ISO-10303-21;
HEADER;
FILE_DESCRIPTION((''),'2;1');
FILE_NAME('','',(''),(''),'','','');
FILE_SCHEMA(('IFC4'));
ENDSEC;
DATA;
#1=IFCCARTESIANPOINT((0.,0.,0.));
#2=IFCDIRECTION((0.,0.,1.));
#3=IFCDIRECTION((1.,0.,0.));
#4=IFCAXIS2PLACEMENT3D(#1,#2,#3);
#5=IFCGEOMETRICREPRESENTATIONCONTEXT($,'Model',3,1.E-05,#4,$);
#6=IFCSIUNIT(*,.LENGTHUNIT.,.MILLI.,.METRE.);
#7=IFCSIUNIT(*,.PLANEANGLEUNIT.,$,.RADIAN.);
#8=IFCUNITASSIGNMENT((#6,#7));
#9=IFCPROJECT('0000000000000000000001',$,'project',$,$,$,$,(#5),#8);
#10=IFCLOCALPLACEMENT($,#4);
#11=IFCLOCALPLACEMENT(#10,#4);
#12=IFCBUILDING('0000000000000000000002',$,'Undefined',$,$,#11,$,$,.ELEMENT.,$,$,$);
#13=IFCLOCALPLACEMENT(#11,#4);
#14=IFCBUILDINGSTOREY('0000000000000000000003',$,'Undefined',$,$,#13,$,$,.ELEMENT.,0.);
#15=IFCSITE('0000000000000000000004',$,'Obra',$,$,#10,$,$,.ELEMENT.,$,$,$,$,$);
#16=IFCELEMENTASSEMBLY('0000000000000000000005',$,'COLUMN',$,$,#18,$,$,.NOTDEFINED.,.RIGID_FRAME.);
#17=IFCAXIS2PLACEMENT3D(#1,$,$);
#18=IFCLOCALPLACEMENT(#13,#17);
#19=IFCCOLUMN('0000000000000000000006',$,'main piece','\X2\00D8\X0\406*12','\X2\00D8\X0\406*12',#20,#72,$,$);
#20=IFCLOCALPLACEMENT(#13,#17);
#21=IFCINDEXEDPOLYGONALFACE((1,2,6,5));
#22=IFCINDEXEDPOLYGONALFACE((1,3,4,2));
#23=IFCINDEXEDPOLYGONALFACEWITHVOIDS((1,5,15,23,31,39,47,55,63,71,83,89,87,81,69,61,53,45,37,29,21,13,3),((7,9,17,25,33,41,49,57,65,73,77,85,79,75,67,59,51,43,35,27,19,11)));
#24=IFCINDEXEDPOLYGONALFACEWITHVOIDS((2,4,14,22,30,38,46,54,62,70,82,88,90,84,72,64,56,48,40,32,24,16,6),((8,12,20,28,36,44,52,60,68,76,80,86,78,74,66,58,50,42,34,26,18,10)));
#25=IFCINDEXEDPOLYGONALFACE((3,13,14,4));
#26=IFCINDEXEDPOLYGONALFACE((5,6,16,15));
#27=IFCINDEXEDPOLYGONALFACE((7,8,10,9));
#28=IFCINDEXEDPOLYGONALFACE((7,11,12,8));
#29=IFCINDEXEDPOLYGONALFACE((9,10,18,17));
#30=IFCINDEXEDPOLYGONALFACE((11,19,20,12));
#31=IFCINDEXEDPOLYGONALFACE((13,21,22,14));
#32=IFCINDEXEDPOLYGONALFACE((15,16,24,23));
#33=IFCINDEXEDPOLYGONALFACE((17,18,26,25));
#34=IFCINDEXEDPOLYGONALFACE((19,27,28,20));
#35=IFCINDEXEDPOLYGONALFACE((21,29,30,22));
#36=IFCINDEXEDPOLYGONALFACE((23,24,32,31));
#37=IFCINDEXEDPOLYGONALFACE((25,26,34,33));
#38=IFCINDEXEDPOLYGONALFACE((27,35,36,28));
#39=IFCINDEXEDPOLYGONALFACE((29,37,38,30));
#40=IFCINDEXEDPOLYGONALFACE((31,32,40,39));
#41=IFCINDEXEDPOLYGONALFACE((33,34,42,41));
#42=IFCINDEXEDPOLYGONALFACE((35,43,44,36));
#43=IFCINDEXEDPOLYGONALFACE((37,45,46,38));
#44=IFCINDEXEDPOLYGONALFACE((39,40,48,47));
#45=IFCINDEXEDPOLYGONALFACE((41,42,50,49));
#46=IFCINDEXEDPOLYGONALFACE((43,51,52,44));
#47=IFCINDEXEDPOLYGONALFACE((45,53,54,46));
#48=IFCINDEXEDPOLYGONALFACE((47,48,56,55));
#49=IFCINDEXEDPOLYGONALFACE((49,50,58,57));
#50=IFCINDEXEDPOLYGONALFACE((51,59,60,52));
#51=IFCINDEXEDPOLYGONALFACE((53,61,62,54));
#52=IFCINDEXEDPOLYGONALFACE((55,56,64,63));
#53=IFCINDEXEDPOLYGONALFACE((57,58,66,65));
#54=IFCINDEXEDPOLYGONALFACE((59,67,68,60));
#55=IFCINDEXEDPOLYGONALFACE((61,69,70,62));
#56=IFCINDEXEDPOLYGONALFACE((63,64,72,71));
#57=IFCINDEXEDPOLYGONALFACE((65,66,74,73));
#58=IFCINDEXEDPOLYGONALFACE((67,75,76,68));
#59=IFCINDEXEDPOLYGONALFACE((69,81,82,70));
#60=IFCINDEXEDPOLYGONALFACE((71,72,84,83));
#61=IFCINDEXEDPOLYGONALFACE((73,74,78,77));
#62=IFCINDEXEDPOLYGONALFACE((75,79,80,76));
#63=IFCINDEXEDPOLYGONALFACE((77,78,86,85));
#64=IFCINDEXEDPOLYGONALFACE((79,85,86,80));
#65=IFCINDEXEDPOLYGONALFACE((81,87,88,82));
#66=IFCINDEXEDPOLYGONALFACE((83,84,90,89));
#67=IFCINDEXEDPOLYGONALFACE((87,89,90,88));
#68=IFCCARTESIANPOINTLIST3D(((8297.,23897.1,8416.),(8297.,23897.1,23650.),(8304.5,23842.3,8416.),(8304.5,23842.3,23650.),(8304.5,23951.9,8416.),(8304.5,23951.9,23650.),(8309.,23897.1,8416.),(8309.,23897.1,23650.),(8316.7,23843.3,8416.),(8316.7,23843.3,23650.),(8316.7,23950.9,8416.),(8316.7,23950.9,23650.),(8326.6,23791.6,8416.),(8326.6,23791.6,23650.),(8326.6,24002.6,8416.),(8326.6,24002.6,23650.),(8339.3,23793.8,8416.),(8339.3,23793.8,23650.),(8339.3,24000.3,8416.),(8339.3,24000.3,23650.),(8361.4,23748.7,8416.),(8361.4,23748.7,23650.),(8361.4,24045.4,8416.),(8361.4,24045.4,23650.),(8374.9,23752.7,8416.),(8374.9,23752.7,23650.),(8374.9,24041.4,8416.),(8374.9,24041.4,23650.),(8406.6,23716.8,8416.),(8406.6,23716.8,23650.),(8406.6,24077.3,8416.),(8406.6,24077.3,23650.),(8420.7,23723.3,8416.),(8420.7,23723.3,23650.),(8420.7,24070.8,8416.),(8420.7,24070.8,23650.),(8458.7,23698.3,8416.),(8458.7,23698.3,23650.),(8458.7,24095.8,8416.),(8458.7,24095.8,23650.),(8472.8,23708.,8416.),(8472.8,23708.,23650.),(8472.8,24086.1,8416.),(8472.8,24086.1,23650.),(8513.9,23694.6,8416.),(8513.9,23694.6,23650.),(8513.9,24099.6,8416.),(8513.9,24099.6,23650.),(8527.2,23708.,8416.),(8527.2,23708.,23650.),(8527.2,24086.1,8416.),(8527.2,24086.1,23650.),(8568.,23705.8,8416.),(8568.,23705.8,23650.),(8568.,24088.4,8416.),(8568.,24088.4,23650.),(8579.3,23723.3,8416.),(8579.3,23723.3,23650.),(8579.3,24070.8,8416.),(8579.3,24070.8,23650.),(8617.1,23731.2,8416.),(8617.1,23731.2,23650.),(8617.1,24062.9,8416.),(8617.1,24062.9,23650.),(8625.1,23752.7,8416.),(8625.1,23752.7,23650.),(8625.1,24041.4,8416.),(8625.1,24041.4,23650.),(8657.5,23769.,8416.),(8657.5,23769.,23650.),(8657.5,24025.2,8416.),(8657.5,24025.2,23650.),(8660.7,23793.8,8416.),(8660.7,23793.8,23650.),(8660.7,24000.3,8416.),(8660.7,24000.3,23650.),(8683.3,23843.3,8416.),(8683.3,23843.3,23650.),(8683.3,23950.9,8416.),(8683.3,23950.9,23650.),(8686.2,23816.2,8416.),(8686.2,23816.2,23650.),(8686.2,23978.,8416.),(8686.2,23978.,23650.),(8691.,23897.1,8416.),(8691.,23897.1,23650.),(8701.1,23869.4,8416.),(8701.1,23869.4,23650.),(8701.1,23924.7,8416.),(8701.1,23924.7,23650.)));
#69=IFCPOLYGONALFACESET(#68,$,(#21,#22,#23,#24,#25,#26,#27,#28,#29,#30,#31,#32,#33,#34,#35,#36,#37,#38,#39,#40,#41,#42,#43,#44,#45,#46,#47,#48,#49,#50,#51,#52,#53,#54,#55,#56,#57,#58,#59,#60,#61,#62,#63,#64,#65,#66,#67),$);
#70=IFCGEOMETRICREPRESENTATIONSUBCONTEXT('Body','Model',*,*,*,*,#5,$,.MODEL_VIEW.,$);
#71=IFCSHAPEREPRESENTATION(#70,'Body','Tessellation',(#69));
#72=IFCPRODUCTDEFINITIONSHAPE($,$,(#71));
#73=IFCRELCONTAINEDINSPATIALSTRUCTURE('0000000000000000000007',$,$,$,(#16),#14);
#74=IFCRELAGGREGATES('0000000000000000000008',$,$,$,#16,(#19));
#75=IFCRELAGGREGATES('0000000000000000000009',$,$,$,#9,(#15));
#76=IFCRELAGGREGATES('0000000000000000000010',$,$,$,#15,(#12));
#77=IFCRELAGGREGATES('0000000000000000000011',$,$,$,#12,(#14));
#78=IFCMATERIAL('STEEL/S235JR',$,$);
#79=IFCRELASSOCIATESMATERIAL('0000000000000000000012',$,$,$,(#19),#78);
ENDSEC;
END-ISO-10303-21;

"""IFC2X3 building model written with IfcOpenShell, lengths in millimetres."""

from ifc_helpers import new_model, si_unit, frame, origin_with_axes, origin_2d_with_axis, place, context, subcontext, project, spatial, hollow_circle, extrude, clip, halfspace, material, element, aggregate, save


model = new_model("IFC2X3")

# Units and contexts
model_context = context("Model", 3, precision=1e-05, world=origin_with_axes())
body_context = subcontext(model_context, "Body", "Model", "MODEL_VIEW")
ifc_project = project(units=[si_unit("LENGTHUNIT", "METRE", prefix="MILLI"), si_unit("PLANEANGLEUNIT", "RADIAN")], contexts=[model_context])

# Site, building, storey
site_placement = place(None, origin_with_axes())
site = spatial("IfcSite", under=ifc_project, at=site_placement, Name="Obra", CompositionType="ELEMENT")
building_placement = place(site_placement, origin_with_axes())
building = spatial("IfcBuilding", under=site, at=building_placement, Name="Undefined", CompositionType="ELEMENT")
storey_placement = place(building_placement, origin_with_axes())
storey = spatial("IfcBuildingStorey", under=building, at=storey_placement, Name="Undefined", CompositionType="ELEMENT", Elevation=0.0)

# Element assembly, column
assembly_1_placement = place(storey_placement, origin_with_axes())
assembly_1 = element("IfcElementAssembly", 1, at=assembly_1_placement, inside=storey, Name="COLUMN", AssemblyPlace="NOTDEFINED", PredefinedType="RIGID_FRAME")
ifc_material_1 = material(Name="STEEL/S235JR")
column_placement = place(assembly_1_placement, frame((8500.0, 23897.1, 8400.0), z_axis=(0.0, 0.0, 1.0), x_axis=(0.0, 1.0, 0.0)))
column = element("IfcColumn", 2, at=column_placement, material=ifc_material_1, Name="main piece", Description="Ø406*12", ObjectType="Ø406*12", context=body_context, shape_type="Clipping", body=[
    clip(extrude(hollow_circle(Radius=203.0, WallThickness=12.0, at=origin_2d_with_axis()), frame((0.0, 0.0, 15250.0), z_axis=(0.0, 0.0, -1.0), x_axis=(0.0, 1.0, 0.0)), (0.0, 0.0, 1.0), 15234.0), halfspace(frame((-203.0, 0.0, 16.0), z_axis=(0.0, 0.0, 1.0), x_axis=(0.0, 1.0, 0.0)), True)),
])

aggregate(assembly_1, [column])

save(model, "model.ifc")
